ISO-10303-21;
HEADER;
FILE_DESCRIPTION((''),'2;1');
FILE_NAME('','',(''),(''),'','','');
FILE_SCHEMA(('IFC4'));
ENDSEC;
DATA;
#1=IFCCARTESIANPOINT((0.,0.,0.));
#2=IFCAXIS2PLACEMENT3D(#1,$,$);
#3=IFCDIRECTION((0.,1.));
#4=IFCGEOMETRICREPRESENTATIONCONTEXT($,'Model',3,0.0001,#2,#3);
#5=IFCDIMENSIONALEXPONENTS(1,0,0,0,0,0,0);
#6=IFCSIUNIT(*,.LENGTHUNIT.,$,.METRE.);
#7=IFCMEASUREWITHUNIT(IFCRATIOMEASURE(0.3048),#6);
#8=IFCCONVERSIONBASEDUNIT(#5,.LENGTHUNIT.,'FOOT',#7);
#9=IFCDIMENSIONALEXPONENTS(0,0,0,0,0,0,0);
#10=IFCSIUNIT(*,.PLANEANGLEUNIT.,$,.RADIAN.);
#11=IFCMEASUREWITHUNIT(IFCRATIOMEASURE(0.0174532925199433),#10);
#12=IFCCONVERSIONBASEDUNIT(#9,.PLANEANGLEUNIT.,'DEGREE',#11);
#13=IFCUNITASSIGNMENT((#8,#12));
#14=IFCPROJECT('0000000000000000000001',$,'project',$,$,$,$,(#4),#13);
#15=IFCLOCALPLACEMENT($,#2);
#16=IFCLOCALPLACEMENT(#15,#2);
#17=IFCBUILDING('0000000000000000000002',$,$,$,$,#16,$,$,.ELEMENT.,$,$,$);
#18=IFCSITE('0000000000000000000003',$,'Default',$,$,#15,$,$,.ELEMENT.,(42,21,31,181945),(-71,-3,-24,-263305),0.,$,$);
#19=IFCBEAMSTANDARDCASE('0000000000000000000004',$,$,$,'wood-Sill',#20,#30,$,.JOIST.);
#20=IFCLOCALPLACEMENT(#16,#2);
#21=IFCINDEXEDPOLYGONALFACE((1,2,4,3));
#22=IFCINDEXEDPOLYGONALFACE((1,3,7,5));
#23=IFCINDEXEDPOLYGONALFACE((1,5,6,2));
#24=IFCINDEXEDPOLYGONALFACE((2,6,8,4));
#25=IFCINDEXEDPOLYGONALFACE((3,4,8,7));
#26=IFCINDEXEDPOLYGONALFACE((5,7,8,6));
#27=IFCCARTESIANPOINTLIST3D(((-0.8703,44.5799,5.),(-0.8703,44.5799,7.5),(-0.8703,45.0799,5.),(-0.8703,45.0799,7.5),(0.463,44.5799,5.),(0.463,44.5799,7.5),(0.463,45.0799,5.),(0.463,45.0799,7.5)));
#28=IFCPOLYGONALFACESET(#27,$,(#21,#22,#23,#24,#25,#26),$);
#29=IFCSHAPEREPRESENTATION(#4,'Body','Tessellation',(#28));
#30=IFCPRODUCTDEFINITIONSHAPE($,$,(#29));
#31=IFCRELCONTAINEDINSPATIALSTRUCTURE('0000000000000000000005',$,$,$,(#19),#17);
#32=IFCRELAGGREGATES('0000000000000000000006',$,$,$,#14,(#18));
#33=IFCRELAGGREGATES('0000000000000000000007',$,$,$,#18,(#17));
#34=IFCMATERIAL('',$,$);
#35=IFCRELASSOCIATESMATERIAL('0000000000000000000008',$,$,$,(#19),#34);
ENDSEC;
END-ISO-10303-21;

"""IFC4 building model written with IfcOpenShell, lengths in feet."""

from ifc_helpers import new_model, entity, si_unit, converted_unit, direction, frame, origin, place, context, project, spatial, rectangle, extrude, material, element, save


model = new_model("IFC4")

# Units and contexts
model_context = context("Model", 3, precision=0.0001, world=origin(), true_north=direction((0.0, 1.0)))
ifc_project = project(units=[converted_unit("LENGTHUNIT", "FOOT", entity("IfcRatioMeasure", 0.3048), si_unit("LENGTHUNIT", "METRE"), dimensions=[1, 0, 0, 0, 0, 0, 0]), converted_unit("PLANEANGLEUNIT", "DEGREE", entity("IfcRatioMeasure", 0.0174532925199433), si_unit("PLANEANGLEUNIT", "RADIAN"), dimensions=[0, 0, 0, 0, 0, 0, 0])], contexts=[model_context])

# Site, building
site_placement = place(None, origin())
site = spatial("IfcSite", under=ifc_project, at=site_placement, Name="Default", CompositionType="ELEMENT", RefLatitude=(42, 21, 31, 181945), RefLongitude=(-71, -3, -24, -263305), RefElevation=0.0)
building_placement = place(site_placement, origin())
building = spatial("IfcBuilding", under=site, at=building_placement, CompositionType="ELEMENT")

# Beam
ifc_material = material(Name="")
placement_1 = place(building_placement, origin())
placement_2 = place(placement_1, frame((-7.7036, 44.8299, 0.0)))
beam_1_placement = place(placement_2, frame((7.5, 0.0, 5.0)))
element("IfcBeamStandardCase", 1, at=beam_1_placement, inside=building, material=ifc_material, ObjectType="wood-Sill", PredefinedType="JOIST", context=model_context, shape_type="SweptSolid", body=[
    extrude(rectangle(XDim=1.3333, YDim=0.5), origin(), (0.0, 0.0, 1.0), 2.5),
])

save(model, "model.ifc")
